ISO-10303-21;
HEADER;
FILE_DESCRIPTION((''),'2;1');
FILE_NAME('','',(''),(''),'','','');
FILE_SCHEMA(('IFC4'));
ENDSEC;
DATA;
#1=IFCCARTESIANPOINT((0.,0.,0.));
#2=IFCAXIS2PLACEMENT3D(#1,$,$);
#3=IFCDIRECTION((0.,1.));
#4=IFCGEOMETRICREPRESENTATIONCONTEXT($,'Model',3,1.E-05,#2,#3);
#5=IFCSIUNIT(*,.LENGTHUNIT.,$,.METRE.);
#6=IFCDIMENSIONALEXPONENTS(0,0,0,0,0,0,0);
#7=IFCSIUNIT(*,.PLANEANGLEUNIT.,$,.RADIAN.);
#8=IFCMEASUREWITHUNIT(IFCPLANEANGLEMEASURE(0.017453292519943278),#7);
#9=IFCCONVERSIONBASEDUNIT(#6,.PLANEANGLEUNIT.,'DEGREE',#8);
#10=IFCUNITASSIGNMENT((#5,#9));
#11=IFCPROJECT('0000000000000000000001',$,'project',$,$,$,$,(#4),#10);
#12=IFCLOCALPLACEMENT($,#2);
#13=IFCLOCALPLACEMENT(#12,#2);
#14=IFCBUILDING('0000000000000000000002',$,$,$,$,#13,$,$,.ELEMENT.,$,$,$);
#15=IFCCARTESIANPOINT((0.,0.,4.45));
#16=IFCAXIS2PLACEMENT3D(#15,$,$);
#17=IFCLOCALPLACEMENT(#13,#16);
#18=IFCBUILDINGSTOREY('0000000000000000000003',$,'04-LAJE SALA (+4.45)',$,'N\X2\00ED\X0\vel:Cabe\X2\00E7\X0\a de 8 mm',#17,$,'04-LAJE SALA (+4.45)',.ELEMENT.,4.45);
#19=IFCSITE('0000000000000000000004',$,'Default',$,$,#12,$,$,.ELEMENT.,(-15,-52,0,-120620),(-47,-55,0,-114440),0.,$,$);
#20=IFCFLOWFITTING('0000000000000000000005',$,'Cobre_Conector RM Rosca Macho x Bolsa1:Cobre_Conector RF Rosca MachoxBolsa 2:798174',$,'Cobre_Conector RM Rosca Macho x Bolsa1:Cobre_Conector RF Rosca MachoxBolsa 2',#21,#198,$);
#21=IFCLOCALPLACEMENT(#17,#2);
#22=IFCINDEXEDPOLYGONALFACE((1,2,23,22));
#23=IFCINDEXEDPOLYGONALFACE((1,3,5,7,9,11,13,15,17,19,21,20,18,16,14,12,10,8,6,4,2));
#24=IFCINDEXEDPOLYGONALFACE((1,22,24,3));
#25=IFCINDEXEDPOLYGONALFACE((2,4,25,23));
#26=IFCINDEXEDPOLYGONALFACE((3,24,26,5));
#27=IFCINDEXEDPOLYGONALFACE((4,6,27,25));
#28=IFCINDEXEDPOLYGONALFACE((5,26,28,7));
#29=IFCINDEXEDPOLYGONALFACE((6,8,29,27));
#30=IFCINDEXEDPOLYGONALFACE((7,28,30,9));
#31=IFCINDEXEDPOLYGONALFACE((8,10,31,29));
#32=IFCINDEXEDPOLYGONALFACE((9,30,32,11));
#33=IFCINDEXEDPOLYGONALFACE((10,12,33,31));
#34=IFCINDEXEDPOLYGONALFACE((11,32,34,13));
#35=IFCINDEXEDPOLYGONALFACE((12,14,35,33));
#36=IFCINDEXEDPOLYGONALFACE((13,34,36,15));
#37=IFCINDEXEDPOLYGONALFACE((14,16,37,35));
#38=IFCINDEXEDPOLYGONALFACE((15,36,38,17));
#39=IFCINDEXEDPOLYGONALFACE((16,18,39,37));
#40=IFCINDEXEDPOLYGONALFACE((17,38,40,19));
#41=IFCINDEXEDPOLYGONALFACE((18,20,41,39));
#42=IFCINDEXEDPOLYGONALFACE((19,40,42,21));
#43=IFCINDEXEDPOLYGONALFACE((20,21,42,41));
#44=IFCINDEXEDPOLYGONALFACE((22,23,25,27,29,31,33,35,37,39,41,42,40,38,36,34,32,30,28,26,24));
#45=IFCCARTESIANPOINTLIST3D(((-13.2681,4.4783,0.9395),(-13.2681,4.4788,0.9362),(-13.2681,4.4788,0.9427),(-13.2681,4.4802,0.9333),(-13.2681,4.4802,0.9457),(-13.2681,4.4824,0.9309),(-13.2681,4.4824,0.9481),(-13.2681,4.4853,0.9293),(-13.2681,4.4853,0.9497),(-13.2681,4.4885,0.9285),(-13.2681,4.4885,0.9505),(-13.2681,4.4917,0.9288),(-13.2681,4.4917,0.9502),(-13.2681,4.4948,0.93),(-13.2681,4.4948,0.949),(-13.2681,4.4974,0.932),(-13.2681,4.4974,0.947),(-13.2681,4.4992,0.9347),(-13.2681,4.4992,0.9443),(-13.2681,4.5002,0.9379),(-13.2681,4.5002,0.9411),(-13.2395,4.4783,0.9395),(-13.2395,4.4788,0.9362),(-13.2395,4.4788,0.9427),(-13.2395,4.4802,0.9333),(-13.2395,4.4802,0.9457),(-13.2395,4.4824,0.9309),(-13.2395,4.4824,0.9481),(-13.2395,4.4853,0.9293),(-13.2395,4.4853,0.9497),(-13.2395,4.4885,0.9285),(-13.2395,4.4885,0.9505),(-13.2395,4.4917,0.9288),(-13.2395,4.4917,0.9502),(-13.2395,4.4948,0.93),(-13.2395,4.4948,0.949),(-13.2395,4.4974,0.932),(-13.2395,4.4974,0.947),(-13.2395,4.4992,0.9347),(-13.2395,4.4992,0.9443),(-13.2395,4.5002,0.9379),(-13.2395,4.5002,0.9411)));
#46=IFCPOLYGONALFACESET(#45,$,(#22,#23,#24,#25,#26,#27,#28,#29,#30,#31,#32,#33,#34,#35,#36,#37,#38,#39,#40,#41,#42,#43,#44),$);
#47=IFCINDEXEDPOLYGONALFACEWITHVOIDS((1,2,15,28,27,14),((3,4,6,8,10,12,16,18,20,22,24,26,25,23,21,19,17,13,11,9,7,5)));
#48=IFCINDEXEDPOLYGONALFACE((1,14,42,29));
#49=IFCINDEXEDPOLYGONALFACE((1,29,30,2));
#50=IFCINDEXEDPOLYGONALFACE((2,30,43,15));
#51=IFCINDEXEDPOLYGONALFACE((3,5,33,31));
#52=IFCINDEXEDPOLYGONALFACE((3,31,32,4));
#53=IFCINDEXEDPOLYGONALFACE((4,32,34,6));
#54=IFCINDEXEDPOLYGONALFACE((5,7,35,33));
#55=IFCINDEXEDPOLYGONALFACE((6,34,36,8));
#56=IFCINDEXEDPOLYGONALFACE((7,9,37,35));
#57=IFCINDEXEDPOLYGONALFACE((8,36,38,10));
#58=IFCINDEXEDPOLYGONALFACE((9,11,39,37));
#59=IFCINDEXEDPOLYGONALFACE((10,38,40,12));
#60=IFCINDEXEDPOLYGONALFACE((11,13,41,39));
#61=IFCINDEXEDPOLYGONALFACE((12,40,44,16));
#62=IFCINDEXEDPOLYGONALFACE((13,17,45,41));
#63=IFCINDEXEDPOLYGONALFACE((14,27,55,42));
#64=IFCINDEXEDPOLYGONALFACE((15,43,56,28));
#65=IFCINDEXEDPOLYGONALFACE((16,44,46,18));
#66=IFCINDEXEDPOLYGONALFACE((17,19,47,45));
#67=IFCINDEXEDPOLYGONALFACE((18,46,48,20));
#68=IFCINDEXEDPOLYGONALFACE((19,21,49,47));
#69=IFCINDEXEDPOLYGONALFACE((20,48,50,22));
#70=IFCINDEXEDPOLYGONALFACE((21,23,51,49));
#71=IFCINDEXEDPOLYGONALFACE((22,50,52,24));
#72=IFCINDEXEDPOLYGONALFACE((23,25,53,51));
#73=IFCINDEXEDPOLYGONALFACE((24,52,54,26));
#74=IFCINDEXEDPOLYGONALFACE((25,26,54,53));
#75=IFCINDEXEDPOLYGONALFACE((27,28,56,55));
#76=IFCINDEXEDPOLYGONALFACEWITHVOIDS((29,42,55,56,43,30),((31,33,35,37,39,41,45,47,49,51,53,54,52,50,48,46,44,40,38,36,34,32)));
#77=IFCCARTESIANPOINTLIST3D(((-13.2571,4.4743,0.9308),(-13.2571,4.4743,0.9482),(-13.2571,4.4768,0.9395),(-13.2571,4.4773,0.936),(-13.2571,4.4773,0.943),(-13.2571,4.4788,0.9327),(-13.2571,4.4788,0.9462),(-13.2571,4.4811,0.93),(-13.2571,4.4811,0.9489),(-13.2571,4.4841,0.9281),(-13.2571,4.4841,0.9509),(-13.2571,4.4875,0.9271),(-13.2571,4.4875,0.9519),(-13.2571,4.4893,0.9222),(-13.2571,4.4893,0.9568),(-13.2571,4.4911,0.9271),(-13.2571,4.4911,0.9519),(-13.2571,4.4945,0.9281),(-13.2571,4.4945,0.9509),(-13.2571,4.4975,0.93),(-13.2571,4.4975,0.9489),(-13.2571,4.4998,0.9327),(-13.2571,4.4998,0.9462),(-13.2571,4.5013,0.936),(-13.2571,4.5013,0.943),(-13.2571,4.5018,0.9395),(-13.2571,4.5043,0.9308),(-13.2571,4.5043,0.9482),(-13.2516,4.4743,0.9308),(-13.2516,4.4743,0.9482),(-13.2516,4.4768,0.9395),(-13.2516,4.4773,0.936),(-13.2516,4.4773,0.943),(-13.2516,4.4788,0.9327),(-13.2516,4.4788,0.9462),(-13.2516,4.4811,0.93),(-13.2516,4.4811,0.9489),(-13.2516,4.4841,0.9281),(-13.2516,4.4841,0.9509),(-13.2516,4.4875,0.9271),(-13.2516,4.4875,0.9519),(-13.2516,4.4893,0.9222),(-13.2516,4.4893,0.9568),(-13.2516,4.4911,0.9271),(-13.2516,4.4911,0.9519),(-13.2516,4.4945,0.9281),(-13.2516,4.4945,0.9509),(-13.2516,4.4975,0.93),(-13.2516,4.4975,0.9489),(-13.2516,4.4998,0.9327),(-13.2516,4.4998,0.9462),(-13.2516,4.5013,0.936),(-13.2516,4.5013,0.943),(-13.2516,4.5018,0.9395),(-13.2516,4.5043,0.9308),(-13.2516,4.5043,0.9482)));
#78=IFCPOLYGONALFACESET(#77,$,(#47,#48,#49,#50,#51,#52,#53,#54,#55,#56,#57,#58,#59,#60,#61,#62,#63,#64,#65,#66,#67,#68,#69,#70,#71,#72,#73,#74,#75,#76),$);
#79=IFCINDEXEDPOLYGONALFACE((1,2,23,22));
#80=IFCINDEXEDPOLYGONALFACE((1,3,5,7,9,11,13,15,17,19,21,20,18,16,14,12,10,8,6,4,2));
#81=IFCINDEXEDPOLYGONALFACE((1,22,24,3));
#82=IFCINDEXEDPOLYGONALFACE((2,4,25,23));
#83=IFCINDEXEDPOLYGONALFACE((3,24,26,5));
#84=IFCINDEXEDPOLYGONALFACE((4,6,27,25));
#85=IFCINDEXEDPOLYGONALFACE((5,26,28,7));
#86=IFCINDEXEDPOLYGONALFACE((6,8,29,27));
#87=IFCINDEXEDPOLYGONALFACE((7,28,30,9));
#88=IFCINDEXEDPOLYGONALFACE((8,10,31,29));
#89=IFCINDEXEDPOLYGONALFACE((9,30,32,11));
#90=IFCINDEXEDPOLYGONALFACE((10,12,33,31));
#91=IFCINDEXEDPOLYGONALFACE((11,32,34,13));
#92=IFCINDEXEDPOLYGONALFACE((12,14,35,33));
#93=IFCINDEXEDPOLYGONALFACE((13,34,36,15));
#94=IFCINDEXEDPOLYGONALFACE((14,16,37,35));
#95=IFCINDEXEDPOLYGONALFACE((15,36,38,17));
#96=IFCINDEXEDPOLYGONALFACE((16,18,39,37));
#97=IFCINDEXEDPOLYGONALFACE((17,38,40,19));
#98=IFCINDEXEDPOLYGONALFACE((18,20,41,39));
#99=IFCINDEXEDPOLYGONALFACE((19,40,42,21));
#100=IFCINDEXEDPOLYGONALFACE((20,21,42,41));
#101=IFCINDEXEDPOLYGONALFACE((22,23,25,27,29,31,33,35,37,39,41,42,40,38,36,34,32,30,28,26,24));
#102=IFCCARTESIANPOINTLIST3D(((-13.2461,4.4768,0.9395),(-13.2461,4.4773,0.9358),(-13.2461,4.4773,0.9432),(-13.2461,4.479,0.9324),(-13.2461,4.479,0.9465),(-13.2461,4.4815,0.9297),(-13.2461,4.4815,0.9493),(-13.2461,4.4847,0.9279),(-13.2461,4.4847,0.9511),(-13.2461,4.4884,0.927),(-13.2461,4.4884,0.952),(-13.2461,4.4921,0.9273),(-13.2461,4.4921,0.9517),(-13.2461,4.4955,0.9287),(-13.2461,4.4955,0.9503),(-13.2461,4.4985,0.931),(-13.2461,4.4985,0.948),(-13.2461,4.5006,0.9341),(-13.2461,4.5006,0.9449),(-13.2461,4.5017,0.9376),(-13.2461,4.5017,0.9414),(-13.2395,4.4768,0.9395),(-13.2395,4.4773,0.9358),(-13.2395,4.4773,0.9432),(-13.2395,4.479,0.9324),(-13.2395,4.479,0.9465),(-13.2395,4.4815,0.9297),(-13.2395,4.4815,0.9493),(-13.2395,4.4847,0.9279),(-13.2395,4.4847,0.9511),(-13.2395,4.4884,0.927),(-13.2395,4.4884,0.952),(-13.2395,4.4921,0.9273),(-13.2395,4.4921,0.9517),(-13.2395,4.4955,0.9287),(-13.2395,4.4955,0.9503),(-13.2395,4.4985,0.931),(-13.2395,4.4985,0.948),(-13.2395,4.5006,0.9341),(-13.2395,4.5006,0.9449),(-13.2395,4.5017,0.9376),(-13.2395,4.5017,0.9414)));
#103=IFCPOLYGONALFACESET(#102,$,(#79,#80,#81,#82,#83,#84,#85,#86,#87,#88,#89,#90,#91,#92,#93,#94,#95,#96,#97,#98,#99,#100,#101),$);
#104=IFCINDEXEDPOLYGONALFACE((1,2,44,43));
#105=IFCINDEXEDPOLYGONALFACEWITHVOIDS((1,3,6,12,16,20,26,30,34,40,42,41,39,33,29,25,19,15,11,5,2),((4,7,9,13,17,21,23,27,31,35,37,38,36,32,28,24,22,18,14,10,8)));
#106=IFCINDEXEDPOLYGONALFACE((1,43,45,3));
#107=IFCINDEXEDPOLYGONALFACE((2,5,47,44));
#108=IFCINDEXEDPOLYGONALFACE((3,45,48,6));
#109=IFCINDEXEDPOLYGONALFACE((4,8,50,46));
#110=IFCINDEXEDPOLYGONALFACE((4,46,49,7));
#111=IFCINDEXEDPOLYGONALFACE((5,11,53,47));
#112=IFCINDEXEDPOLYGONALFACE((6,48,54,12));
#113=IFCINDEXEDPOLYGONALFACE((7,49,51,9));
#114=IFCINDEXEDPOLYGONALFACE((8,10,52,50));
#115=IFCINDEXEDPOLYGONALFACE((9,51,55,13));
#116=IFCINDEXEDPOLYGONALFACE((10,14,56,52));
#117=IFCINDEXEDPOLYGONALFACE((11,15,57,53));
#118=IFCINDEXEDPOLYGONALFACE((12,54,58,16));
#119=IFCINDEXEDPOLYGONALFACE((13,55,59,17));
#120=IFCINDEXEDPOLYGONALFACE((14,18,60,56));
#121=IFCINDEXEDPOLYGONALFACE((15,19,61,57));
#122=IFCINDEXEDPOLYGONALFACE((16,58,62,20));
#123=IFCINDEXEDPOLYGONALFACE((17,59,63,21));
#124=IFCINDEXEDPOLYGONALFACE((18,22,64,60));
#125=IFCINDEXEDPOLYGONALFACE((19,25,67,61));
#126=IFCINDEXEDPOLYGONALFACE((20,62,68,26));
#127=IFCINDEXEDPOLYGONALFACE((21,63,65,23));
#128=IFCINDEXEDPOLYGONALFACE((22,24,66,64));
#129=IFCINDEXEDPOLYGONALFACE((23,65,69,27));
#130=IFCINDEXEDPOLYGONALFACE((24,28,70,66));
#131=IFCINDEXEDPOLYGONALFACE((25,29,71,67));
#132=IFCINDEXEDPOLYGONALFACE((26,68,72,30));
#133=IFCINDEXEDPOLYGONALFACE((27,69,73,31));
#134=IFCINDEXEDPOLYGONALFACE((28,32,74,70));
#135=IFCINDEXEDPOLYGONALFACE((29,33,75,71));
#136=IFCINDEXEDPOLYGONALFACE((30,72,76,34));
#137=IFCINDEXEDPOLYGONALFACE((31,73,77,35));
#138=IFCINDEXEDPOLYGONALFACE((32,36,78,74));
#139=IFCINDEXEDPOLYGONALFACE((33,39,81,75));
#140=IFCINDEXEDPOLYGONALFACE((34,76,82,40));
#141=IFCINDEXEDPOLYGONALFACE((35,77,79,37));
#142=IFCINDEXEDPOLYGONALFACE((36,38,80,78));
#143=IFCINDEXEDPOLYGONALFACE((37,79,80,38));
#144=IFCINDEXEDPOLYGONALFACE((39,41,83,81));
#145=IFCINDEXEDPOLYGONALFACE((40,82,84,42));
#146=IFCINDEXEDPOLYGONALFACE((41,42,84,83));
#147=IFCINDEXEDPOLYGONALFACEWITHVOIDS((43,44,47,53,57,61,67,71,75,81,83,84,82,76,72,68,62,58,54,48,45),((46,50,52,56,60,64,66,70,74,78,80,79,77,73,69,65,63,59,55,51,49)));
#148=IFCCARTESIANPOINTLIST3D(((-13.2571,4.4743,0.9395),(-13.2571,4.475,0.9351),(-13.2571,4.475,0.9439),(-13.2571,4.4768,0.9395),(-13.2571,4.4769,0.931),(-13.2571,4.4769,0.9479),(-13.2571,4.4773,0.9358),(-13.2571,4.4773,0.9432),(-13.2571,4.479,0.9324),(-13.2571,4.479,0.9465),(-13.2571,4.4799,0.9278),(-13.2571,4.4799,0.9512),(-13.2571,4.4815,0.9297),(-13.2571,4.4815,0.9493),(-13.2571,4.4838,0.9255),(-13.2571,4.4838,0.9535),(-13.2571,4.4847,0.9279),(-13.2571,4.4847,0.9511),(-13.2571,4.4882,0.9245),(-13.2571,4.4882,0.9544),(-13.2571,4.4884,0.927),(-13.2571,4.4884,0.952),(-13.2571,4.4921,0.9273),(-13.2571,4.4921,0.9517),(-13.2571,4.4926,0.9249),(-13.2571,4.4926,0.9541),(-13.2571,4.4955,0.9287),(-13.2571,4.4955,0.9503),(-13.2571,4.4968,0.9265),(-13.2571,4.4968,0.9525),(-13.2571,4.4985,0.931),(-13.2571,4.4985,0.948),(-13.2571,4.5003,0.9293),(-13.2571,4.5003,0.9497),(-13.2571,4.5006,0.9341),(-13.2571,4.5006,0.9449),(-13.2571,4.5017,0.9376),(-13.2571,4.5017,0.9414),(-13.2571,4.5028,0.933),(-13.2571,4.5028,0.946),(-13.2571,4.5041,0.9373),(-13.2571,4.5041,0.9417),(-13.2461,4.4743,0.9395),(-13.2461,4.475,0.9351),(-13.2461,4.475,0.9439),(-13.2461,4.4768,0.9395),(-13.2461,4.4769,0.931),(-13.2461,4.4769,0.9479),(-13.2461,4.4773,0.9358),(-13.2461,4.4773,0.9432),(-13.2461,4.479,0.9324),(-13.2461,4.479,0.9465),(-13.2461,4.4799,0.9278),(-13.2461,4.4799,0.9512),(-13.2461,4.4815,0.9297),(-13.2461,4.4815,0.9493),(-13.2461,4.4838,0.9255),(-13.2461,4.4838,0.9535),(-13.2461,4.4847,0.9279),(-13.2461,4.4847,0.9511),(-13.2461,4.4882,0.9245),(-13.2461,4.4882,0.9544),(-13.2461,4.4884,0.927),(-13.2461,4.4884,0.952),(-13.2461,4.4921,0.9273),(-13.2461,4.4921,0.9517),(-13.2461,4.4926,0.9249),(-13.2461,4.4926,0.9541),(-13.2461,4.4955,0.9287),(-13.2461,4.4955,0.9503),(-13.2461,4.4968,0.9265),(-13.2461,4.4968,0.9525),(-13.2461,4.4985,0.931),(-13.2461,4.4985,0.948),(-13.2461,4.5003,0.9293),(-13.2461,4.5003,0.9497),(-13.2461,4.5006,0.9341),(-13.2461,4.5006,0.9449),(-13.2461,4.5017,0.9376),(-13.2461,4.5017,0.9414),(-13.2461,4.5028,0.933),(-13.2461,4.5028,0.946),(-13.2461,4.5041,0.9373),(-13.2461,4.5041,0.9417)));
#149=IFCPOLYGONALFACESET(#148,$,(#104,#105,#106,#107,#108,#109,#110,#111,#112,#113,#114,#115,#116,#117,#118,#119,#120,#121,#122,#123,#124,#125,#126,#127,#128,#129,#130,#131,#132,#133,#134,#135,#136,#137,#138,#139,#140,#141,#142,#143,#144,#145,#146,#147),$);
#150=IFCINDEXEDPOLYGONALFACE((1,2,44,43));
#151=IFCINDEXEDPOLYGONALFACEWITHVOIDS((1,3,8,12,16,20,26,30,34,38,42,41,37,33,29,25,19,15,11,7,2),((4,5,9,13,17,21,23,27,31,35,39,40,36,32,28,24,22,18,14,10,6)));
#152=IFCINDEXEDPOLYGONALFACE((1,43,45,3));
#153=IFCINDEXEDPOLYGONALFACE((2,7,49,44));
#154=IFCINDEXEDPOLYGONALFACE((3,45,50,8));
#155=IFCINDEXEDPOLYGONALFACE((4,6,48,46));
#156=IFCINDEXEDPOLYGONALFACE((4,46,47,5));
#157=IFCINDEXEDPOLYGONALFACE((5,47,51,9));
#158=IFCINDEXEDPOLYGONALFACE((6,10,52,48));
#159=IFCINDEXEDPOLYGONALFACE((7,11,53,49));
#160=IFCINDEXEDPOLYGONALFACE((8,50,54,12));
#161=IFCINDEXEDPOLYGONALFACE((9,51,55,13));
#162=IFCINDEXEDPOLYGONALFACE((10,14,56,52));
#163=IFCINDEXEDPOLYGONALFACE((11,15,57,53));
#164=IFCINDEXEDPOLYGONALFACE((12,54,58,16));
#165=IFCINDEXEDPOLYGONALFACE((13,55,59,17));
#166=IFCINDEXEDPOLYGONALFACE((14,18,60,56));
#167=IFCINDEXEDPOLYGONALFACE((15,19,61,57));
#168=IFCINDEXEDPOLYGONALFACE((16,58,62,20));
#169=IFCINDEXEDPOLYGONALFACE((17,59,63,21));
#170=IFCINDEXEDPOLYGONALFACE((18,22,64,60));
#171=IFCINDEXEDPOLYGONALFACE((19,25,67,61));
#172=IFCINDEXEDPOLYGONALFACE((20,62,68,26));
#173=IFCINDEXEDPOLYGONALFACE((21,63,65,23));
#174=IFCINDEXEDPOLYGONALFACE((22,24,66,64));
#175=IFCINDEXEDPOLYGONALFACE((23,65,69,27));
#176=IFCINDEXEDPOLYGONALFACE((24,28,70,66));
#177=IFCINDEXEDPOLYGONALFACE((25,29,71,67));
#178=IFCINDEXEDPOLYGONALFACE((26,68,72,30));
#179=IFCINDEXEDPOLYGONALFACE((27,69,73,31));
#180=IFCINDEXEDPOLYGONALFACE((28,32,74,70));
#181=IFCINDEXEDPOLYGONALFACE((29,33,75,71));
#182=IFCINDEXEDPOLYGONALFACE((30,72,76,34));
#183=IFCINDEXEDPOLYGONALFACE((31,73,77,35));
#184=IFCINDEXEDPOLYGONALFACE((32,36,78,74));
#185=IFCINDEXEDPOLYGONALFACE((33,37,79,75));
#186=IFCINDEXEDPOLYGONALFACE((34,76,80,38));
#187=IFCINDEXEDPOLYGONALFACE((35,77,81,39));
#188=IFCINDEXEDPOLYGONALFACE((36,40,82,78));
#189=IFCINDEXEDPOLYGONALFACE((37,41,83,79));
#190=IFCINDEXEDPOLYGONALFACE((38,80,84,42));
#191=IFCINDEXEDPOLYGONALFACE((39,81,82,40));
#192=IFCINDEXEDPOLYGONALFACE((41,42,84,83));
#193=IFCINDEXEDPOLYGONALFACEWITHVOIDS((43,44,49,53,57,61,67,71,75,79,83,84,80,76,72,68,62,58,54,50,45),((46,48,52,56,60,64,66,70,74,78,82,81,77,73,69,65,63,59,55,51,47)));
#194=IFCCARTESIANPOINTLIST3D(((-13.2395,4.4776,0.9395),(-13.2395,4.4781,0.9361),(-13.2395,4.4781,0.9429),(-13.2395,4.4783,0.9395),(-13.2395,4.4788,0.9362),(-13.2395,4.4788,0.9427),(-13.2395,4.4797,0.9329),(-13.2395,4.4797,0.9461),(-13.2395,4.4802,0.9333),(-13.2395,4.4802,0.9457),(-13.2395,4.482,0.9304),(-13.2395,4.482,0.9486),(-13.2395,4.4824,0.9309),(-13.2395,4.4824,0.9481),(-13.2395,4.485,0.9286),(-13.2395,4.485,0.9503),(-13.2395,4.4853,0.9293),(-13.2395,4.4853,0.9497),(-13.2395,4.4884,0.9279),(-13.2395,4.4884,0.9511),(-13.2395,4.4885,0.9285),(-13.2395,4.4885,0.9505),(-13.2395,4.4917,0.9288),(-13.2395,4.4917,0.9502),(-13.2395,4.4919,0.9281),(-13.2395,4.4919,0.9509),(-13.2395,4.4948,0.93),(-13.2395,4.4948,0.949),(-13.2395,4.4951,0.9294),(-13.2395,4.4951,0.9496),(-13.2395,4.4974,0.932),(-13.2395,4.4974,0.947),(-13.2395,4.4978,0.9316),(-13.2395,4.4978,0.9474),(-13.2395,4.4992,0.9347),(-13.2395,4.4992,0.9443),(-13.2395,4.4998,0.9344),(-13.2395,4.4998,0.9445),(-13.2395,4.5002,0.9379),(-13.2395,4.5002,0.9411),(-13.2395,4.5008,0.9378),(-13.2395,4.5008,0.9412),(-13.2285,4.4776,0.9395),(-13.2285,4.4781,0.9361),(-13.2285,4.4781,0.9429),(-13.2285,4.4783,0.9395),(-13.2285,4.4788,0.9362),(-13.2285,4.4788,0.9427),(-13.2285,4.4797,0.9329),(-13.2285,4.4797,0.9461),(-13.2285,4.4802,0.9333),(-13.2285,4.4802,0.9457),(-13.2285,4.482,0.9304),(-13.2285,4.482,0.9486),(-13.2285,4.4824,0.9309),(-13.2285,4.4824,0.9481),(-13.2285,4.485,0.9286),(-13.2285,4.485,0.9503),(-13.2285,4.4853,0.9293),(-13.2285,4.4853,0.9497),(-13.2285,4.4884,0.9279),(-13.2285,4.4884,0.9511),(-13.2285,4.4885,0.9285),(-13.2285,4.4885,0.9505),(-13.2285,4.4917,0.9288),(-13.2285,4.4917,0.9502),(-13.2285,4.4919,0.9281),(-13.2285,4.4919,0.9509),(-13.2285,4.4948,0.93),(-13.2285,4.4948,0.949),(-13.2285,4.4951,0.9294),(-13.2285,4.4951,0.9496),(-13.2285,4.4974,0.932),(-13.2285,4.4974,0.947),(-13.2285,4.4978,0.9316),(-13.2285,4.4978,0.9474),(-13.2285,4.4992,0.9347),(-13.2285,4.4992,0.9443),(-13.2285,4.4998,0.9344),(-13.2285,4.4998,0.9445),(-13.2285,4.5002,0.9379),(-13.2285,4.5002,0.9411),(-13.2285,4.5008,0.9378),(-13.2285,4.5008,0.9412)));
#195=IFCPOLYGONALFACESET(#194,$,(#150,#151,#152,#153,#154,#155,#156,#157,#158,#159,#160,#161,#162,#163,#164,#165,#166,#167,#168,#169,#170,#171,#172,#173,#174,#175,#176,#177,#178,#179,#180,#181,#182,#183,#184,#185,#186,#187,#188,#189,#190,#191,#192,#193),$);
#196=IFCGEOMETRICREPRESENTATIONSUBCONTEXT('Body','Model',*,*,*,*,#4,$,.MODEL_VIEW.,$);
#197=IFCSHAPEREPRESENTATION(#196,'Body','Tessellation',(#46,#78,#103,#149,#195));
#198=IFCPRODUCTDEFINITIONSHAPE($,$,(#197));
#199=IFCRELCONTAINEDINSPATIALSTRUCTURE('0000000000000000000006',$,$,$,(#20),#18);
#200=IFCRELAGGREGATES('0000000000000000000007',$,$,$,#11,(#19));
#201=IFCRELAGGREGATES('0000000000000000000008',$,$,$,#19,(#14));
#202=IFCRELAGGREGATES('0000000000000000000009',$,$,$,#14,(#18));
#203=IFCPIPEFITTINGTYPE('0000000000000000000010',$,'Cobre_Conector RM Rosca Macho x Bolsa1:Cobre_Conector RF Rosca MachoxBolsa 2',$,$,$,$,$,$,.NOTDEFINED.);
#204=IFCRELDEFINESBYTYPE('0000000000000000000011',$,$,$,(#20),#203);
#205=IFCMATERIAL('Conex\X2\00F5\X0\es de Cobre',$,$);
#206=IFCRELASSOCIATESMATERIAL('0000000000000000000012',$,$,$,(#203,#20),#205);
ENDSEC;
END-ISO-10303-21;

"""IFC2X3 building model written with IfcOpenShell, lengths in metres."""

from ifc_helpers import new_model, entity, si_unit, converted_unit, direction, frame, frame_2d, origin, place, context, subcontext, project, spatial, polyline, circle_curve, parameter, trimmed, segment, composite_curve, circle, hollow_circle, outline, extrude, source, transform, mapped, material, type_object, type_shapes, element, save


model = new_model("IFC2X3")

# Units and contexts
model_context = context("Model", 3, precision=1e-05, world=origin(), true_north=direction((0.0, 1.0)))
body_context = subcontext(model_context, "Body", "Model", "MODEL_VIEW")
ifc_project = project(units=[si_unit("LENGTHUNIT", "METRE"), converted_unit("PLANEANGLEUNIT", "DEGREE", entity("IfcPlaneAngleMeasure", 0.017453292519943278), si_unit("PLANEANGLEUNIT", "RADIAN"), dimensions=[0, 0, 0, 0, 0, 0, 0])], contexts=[model_context])

# Site, building, storey
site_placement = place(None, origin())
site = spatial("IfcSite", under=ifc_project, at=site_placement, Name="Default", CompositionType="ELEMENT", RefLatitude=(-15, -52, 0, -120620), RefLongitude=(-47, -55, 0, -114440), RefElevation=0.0)
building_placement = place(site_placement, origin())
building = spatial("IfcBuilding", under=site, at=building_placement, CompositionType="ELEMENT")
storey_placement = place(building_placement, frame((0.0, 0.0, 4.45)))
storey = spatial("IfcBuildingStorey", under=building, at=storey_placement, Name="04-LAJE SALA (+4.45)", ObjectType="Nível:Cabeça de 8 mm", LongName="04-LAJE SALA (+4.45)", CompositionType="ELEMENT", Elevation=4.45)

# Flow fitting
ifc_material_1 = material(Name="Conexões de Cobre")
pipe_fitting_type_1 = type_object("IfcPipeFittingType", Name="Cobre_Conector RM Rosca Macho x Bolsa1:Cobre_Conector RF Rosca MachoxBolsa 2", PredefinedType="NOTDEFINED", material=ifc_material_1)
shared_shape_1 = source(origin(), body_context, "Body", "SweptSolid", [
    extrude(circle(Radius=0.011, at=frame_2d((0.0, 0.0), x_axis=(1.0, 0.0))), frame((0.011, 0.0, 0.0), z_axis=(1.0, 0.0, 0.0), x_axis=(0.0, 1.0, 0.0)), (0.0, 0.0, 1.0), 0.0286),
    extrude(outline(polyline([(-0.0087, -0.015), (0.0087, -0.015), (0.0173, 0.0), (0.0087, 0.015), (-0.0087, 0.015), (-0.0173, 0.0), (-0.0087, -0.015)]), holes=[composite_curve([segment(trimmed(circle_curve(frame_2d((0.0, 0.0), x_axis=(0.0, 1.0)), 0.0125), [parameter(0.0)], [parameter(180.0)], True, "PARAMETER"), False, "CONTINUOUS"), segment(trimmed(circle_curve(frame_2d((0.0, 0.0), x_axis=(0.0, 1.0)), 0.0125), [parameter(180.0)], [parameter(0.0)], True, "PARAMETER"), False, "CONTINUOUS")], self_intersect=False)]), frame((0.0231, 0.0, 0.0), z_axis=(1.0, 0.0, 0.0), x_axis=(0.0, 0.0, -1.0)), (0.0, 0.0, 1.0), 0.0055),
    extrude(circle(Radius=0.0125, at=frame_2d((0.0, 0.0), x_axis=(1.0, 0.0))), frame((0.011, 0.0, 0.0), z_axis=(1.0, 0.0, 0.0), x_axis=(0.0, 1.0, 0.0)), (0.0, 0.0, 1.0), 0.0066),
    extrude(hollow_circle(Radius=0.015, WallThickness=0.0025, at=frame_2d((0.0, 0.0), x_axis=(1.0, 0.0))), frame((0.0176, 0.0, 0.0), z_axis=(1.0, 0.0, 0.0), x_axis=(0.0, 1.0, 0.0)), (0.0, 0.0, 1.0), 0.011),
    extrude(hollow_circle(Radius=0.0117, WallThickness=0.0007, at=frame_2d((0.0, 0.0), x_axis=(1.0, 0.0))), frame((0.0, 0.0, 0.0), z_axis=(1.0, 0.0, 0.0), x_axis=(0.0, 1.0, 0.0)), (0.0, 0.0, 1.0), 0.011),
])
type_shapes(pipe_fitting_type_1, [shared_shape_1])
flow_fitting_1_placement = place(storey_placement, frame((-13.2285, 4.4893, 0.9395), z_axis=(0.0, 0.0, 1.0), x_axis=(-1.0, 0.0, 0.0)))
element("IfcFlowFitting", 1, at=flow_fitting_1_placement, inside=storey, type_object=pipe_fitting_type_1, material=ifc_material_1, Name="Cobre_Conector RM Rosca Macho x Bolsa1:Cobre_Conector RF Rosca MachoxBolsa 2:798174", ObjectType="Cobre_Conector RM Rosca Macho x Bolsa1:Cobre_Conector RF Rosca MachoxBolsa 2", context=body_context, shape_type="MappedRepresentation", body=[
    mapped(shared_shape_1, transform((0.0, 0.0, 0.0), scale=1.0)),
])

save(model, "model.ifc")
